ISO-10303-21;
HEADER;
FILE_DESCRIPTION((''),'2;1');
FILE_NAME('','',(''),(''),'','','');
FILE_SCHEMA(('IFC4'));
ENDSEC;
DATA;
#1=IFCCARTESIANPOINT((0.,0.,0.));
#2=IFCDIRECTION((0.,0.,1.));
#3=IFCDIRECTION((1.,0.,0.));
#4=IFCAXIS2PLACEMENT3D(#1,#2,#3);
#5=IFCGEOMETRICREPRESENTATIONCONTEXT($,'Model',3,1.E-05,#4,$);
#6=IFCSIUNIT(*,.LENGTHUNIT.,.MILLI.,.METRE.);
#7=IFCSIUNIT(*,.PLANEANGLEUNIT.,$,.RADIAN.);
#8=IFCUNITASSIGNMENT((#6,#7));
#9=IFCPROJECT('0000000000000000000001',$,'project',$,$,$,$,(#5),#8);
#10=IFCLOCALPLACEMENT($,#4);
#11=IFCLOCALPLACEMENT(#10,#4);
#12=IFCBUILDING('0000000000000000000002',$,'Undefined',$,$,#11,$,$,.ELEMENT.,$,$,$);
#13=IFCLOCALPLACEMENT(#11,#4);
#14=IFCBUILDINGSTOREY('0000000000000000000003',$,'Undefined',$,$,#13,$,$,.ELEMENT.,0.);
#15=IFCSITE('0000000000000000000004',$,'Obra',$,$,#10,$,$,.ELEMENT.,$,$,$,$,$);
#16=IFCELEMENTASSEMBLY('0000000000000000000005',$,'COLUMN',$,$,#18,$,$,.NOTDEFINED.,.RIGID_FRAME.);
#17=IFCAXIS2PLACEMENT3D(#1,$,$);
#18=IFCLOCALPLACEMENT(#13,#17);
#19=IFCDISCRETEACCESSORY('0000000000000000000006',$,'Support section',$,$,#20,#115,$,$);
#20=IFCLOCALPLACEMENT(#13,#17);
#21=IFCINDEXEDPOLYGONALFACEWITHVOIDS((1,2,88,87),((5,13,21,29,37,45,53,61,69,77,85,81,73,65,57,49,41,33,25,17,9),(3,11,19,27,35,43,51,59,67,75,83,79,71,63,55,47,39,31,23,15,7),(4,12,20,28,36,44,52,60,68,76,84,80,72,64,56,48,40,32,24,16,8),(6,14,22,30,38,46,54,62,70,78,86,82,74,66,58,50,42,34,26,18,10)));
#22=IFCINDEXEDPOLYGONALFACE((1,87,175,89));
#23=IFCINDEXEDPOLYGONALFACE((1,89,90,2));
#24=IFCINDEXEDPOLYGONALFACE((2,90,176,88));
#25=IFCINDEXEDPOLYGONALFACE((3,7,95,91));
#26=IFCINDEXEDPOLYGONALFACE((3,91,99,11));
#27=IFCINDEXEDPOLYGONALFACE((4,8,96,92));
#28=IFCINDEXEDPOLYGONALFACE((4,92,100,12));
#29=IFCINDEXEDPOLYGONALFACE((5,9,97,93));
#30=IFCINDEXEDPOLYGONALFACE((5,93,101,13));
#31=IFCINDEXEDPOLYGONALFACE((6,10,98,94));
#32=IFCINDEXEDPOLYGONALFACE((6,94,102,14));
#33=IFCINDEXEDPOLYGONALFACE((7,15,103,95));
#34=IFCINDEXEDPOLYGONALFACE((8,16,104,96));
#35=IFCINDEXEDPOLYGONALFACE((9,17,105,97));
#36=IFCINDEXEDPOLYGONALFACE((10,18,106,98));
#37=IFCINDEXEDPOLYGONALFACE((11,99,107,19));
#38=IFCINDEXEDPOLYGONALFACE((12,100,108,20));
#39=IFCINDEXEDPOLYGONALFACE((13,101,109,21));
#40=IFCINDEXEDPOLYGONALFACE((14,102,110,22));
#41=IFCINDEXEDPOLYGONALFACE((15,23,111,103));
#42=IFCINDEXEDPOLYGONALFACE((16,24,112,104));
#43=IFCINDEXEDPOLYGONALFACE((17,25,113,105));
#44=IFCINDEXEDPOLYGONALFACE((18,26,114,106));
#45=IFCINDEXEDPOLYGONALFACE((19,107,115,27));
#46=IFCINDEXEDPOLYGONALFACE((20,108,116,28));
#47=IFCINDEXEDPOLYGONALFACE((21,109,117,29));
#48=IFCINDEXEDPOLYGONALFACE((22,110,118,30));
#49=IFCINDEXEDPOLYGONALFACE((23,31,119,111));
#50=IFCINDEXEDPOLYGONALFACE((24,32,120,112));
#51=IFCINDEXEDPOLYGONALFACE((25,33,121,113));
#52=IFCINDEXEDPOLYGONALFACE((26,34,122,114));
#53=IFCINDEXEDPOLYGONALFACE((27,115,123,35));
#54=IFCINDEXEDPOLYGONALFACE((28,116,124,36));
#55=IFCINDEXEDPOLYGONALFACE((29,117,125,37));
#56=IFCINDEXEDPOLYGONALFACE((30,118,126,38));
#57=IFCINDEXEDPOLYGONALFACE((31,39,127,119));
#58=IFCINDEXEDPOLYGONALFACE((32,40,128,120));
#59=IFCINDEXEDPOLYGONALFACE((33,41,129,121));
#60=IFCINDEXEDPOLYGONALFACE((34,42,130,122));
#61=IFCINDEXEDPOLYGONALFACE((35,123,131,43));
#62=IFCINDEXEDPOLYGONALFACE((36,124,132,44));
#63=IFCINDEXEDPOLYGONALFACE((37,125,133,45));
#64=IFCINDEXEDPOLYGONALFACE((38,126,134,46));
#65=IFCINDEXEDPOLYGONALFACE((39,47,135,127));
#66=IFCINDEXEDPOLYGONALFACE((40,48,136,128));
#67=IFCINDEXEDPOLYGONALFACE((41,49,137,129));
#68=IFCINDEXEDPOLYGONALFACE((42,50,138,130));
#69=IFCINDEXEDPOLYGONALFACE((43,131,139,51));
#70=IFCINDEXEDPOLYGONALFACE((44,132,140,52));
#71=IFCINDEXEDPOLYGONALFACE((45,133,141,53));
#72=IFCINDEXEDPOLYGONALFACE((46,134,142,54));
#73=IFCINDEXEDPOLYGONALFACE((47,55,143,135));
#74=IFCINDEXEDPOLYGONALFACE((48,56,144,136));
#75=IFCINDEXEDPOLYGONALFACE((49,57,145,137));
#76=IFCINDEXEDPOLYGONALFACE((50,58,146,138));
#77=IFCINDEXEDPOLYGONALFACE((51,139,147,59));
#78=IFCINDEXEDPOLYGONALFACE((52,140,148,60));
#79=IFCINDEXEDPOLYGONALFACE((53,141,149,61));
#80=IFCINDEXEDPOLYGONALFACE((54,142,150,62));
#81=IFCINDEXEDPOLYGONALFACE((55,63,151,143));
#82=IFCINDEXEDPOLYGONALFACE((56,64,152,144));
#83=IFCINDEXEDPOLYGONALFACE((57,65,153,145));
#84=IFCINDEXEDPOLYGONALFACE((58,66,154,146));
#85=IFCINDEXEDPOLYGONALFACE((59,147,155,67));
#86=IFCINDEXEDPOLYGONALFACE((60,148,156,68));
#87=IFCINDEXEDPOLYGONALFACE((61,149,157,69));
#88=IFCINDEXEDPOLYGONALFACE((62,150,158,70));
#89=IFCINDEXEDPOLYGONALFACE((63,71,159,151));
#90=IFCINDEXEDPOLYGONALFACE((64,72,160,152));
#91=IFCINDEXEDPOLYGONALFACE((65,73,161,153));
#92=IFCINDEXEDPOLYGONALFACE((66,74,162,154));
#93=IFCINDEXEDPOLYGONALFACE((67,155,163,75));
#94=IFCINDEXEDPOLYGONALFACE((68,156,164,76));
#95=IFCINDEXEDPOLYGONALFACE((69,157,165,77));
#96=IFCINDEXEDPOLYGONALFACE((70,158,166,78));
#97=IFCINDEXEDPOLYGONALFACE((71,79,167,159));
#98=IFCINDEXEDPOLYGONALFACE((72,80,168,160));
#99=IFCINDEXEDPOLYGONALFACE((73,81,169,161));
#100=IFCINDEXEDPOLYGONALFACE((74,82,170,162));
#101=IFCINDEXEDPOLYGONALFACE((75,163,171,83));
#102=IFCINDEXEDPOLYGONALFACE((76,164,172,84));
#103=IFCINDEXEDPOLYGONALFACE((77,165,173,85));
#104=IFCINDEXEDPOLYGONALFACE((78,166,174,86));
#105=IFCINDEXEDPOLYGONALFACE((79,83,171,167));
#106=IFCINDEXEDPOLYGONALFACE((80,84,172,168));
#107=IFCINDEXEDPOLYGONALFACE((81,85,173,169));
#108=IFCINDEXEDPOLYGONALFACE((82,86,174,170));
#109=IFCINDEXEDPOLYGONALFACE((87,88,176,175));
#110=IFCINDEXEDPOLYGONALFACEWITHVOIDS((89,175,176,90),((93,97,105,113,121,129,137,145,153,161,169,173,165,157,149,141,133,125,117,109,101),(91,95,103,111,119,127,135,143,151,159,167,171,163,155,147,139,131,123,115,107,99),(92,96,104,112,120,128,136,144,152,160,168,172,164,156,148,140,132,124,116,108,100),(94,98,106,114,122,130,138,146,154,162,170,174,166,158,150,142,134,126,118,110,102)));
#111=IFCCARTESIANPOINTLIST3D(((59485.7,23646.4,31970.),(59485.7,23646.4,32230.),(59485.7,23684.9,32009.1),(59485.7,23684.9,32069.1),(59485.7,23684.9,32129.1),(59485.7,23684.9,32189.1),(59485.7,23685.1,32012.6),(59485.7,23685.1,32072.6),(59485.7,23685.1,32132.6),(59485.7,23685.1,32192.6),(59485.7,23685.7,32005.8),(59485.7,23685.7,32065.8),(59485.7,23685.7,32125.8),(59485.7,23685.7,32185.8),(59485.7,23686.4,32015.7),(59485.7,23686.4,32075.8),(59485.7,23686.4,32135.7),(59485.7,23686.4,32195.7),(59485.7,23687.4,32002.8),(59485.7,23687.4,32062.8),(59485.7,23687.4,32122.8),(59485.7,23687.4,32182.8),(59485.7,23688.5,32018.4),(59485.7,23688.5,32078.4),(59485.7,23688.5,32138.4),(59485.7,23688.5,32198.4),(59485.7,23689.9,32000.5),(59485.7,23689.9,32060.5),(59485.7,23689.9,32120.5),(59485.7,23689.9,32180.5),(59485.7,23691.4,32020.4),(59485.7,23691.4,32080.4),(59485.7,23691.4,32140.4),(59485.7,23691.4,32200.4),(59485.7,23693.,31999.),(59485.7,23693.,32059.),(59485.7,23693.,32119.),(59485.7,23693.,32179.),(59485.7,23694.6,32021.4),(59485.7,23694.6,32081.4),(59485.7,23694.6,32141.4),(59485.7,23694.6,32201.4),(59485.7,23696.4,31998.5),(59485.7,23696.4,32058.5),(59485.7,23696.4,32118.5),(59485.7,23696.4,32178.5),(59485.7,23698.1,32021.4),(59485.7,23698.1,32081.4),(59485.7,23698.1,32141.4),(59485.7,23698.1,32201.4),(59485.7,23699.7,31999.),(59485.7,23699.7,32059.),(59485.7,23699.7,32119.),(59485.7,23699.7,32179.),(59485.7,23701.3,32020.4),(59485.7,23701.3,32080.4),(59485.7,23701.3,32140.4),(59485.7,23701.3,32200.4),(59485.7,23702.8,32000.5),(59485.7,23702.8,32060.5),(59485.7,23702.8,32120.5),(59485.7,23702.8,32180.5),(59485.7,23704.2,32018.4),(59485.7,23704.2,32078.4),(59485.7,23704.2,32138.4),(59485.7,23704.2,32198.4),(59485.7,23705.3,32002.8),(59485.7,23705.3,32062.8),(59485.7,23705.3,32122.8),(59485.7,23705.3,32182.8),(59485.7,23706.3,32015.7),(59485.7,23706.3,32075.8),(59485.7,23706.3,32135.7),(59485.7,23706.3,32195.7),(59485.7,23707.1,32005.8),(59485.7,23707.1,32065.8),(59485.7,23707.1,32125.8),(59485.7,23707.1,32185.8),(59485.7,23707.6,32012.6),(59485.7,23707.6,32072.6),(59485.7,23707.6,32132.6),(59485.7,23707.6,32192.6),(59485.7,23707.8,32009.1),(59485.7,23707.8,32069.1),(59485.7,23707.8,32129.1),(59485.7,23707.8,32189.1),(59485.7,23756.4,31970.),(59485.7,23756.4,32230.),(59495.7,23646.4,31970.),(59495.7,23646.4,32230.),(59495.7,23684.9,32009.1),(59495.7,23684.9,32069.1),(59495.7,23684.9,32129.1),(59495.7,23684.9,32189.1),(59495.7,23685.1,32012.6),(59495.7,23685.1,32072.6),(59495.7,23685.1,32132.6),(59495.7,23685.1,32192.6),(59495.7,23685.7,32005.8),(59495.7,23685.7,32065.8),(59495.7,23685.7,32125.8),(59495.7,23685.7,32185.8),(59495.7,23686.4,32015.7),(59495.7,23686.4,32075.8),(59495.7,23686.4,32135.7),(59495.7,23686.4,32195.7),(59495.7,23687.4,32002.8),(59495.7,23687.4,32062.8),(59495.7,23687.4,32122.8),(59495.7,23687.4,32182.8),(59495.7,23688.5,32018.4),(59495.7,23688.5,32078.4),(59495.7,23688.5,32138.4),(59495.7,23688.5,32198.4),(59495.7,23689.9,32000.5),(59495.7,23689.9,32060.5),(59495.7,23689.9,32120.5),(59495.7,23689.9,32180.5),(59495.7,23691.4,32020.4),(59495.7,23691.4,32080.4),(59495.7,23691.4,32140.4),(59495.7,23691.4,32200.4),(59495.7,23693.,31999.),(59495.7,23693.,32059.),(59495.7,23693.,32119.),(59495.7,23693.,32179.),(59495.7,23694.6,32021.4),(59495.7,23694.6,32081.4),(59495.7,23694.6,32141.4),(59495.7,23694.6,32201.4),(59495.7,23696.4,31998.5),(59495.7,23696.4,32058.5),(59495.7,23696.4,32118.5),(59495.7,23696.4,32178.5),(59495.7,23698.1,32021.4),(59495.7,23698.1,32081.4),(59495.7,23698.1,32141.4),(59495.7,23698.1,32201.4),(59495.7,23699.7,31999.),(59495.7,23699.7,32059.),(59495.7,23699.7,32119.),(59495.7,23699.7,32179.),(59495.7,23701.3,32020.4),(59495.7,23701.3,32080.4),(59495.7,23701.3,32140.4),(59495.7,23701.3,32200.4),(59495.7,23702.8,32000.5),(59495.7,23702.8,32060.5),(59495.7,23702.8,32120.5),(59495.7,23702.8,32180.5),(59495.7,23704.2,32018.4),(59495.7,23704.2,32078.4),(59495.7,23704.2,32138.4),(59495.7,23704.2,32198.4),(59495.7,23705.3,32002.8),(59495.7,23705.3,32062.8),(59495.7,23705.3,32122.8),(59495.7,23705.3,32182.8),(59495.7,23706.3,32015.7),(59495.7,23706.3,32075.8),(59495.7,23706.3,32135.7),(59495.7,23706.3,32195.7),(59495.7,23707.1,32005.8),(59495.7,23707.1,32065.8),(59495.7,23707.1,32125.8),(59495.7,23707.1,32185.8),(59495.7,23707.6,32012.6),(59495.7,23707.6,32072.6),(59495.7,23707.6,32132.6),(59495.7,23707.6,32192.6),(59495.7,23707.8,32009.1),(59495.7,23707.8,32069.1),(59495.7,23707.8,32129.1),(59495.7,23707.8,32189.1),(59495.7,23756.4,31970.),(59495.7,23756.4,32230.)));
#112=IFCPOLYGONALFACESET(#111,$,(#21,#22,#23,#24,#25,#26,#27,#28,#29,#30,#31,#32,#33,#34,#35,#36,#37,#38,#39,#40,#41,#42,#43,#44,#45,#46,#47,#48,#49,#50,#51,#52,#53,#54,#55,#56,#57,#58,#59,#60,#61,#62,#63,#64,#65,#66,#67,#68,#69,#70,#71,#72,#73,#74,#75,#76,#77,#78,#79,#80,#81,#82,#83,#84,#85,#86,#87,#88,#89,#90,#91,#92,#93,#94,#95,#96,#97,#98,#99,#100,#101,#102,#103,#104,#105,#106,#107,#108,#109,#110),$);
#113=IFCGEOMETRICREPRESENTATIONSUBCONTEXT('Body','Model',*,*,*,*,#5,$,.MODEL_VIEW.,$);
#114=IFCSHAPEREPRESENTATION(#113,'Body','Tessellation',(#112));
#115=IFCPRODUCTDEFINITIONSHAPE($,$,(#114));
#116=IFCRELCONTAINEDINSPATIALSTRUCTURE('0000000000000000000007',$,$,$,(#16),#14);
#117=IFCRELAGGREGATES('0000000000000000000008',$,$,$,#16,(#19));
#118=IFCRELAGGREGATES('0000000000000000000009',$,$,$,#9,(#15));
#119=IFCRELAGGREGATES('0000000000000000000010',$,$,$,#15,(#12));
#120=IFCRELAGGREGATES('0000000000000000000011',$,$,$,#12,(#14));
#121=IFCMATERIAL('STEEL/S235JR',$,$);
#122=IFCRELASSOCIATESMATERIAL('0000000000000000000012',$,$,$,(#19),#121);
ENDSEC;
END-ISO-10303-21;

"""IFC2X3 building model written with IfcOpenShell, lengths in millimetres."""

from ifc_helpers import new_model, si_unit, frame, origin_with_axes, origin_2d_with_axis, place, context, subcontext, project, spatial, rectangle, circle, extrude, source, transform, mapped, material, element, aggregate, save


model = new_model("IFC2X3")

# Units and contexts
model_context = context("Model", 3, precision=1e-05, world=origin_with_axes())
body_context = subcontext(model_context, "Body", "Model", "MODEL_VIEW")
ifc_project = project(units=[si_unit("LENGTHUNIT", "METRE", prefix="MILLI"), si_unit("PLANEANGLEUNIT", "RADIAN")], contexts=[model_context])

# Site, building, storey
site_placement = place(None, origin_with_axes())
site = spatial("IfcSite", under=ifc_project, at=site_placement, Name="Obra", CompositionType="ELEMENT")
building_placement = place(site_placement, origin_with_axes())
building = spatial("IfcBuilding", under=site, at=building_placement, Name="Undefined", CompositionType="ELEMENT")
storey_placement = place(building_placement, origin_with_axes())
storey = spatial("IfcBuildingStorey", under=building, at=storey_placement, Name="Undefined", CompositionType="ELEMENT", Elevation=0.0)

# Element assembly
assembly_1_placement = place(storey_placement, origin_with_axes())
assembly_1 = element("IfcElementAssembly", 1, at=assembly_1_placement, inside=storey, Name="COLUMN", AssemblyPlace="NOTDEFINED", PredefinedType="RIGID_FRAME")
ifc_material_1 = material(Name="STEEL/S235JR")

# Discrete accessory, opening
shared_shape_1 = source(origin_with_axes(), body_context, "Body", "SweptSolid", [
    extrude(circle(Radius=11.5, at=origin_2d_with_axis()), frame((0.0, -14.4, 0.0), z_axis=(0.0, 1.0, 0.0), x_axis=(1.0, 0.0, 0.0)), (0.0, 0.0, 1.0), 10.2),
])
discrete_accessory_1_placement = place(assembly_1_placement, frame((59490.7, 23701.4, 31970.0), z_axis=(0.0, 0.0, 1.0), x_axis=(0.0, 1.0, 0.0)))
discrete_accessory_1 = element("IfcDiscreteAccessory", 2, at=discrete_accessory_1_placement, material=ifc_material_1, Name="Support section", context=body_context, shape_type="SweptSolid", body=[
    extrude(rectangle(XDim=10.0, YDim=110.0, at=origin_2d_with_axis()), frame((0.0, 0.0, 260.0), z_axis=(0.0, 0.0, -1.0), x_axis=(0.0, 1.0, 0.0)), (0.0, 0.0, 1.0), 260.0),
])
opening_1_placement = place(assembly_1_placement, frame((59500.0, 23746.4, 32300.0), z_axis=(0.0, -1.0, 0.0), x_axis=(0.0, 0.0, -1.0)))
element("IfcOpeningElement", 3, at=opening_1_placement, cuts=discrete_accessory_1, ObjectType="Opening", context=body_context, shape_type="MappedRepresentation", body=[
    mapped(shared_shape_1, transform((110.0, 0.0, 50.0))),
    mapped(shared_shape_1, transform((170.0, 0.0, 50.0))),
    mapped(shared_shape_1, transform((230.0, 0.0, 50.0))),
    mapped(shared_shape_1, transform((290.0, 0.0, 50.0))),
])
aggregate(assembly_1, [discrete_accessory_1])

save(model, "model.ifc")
